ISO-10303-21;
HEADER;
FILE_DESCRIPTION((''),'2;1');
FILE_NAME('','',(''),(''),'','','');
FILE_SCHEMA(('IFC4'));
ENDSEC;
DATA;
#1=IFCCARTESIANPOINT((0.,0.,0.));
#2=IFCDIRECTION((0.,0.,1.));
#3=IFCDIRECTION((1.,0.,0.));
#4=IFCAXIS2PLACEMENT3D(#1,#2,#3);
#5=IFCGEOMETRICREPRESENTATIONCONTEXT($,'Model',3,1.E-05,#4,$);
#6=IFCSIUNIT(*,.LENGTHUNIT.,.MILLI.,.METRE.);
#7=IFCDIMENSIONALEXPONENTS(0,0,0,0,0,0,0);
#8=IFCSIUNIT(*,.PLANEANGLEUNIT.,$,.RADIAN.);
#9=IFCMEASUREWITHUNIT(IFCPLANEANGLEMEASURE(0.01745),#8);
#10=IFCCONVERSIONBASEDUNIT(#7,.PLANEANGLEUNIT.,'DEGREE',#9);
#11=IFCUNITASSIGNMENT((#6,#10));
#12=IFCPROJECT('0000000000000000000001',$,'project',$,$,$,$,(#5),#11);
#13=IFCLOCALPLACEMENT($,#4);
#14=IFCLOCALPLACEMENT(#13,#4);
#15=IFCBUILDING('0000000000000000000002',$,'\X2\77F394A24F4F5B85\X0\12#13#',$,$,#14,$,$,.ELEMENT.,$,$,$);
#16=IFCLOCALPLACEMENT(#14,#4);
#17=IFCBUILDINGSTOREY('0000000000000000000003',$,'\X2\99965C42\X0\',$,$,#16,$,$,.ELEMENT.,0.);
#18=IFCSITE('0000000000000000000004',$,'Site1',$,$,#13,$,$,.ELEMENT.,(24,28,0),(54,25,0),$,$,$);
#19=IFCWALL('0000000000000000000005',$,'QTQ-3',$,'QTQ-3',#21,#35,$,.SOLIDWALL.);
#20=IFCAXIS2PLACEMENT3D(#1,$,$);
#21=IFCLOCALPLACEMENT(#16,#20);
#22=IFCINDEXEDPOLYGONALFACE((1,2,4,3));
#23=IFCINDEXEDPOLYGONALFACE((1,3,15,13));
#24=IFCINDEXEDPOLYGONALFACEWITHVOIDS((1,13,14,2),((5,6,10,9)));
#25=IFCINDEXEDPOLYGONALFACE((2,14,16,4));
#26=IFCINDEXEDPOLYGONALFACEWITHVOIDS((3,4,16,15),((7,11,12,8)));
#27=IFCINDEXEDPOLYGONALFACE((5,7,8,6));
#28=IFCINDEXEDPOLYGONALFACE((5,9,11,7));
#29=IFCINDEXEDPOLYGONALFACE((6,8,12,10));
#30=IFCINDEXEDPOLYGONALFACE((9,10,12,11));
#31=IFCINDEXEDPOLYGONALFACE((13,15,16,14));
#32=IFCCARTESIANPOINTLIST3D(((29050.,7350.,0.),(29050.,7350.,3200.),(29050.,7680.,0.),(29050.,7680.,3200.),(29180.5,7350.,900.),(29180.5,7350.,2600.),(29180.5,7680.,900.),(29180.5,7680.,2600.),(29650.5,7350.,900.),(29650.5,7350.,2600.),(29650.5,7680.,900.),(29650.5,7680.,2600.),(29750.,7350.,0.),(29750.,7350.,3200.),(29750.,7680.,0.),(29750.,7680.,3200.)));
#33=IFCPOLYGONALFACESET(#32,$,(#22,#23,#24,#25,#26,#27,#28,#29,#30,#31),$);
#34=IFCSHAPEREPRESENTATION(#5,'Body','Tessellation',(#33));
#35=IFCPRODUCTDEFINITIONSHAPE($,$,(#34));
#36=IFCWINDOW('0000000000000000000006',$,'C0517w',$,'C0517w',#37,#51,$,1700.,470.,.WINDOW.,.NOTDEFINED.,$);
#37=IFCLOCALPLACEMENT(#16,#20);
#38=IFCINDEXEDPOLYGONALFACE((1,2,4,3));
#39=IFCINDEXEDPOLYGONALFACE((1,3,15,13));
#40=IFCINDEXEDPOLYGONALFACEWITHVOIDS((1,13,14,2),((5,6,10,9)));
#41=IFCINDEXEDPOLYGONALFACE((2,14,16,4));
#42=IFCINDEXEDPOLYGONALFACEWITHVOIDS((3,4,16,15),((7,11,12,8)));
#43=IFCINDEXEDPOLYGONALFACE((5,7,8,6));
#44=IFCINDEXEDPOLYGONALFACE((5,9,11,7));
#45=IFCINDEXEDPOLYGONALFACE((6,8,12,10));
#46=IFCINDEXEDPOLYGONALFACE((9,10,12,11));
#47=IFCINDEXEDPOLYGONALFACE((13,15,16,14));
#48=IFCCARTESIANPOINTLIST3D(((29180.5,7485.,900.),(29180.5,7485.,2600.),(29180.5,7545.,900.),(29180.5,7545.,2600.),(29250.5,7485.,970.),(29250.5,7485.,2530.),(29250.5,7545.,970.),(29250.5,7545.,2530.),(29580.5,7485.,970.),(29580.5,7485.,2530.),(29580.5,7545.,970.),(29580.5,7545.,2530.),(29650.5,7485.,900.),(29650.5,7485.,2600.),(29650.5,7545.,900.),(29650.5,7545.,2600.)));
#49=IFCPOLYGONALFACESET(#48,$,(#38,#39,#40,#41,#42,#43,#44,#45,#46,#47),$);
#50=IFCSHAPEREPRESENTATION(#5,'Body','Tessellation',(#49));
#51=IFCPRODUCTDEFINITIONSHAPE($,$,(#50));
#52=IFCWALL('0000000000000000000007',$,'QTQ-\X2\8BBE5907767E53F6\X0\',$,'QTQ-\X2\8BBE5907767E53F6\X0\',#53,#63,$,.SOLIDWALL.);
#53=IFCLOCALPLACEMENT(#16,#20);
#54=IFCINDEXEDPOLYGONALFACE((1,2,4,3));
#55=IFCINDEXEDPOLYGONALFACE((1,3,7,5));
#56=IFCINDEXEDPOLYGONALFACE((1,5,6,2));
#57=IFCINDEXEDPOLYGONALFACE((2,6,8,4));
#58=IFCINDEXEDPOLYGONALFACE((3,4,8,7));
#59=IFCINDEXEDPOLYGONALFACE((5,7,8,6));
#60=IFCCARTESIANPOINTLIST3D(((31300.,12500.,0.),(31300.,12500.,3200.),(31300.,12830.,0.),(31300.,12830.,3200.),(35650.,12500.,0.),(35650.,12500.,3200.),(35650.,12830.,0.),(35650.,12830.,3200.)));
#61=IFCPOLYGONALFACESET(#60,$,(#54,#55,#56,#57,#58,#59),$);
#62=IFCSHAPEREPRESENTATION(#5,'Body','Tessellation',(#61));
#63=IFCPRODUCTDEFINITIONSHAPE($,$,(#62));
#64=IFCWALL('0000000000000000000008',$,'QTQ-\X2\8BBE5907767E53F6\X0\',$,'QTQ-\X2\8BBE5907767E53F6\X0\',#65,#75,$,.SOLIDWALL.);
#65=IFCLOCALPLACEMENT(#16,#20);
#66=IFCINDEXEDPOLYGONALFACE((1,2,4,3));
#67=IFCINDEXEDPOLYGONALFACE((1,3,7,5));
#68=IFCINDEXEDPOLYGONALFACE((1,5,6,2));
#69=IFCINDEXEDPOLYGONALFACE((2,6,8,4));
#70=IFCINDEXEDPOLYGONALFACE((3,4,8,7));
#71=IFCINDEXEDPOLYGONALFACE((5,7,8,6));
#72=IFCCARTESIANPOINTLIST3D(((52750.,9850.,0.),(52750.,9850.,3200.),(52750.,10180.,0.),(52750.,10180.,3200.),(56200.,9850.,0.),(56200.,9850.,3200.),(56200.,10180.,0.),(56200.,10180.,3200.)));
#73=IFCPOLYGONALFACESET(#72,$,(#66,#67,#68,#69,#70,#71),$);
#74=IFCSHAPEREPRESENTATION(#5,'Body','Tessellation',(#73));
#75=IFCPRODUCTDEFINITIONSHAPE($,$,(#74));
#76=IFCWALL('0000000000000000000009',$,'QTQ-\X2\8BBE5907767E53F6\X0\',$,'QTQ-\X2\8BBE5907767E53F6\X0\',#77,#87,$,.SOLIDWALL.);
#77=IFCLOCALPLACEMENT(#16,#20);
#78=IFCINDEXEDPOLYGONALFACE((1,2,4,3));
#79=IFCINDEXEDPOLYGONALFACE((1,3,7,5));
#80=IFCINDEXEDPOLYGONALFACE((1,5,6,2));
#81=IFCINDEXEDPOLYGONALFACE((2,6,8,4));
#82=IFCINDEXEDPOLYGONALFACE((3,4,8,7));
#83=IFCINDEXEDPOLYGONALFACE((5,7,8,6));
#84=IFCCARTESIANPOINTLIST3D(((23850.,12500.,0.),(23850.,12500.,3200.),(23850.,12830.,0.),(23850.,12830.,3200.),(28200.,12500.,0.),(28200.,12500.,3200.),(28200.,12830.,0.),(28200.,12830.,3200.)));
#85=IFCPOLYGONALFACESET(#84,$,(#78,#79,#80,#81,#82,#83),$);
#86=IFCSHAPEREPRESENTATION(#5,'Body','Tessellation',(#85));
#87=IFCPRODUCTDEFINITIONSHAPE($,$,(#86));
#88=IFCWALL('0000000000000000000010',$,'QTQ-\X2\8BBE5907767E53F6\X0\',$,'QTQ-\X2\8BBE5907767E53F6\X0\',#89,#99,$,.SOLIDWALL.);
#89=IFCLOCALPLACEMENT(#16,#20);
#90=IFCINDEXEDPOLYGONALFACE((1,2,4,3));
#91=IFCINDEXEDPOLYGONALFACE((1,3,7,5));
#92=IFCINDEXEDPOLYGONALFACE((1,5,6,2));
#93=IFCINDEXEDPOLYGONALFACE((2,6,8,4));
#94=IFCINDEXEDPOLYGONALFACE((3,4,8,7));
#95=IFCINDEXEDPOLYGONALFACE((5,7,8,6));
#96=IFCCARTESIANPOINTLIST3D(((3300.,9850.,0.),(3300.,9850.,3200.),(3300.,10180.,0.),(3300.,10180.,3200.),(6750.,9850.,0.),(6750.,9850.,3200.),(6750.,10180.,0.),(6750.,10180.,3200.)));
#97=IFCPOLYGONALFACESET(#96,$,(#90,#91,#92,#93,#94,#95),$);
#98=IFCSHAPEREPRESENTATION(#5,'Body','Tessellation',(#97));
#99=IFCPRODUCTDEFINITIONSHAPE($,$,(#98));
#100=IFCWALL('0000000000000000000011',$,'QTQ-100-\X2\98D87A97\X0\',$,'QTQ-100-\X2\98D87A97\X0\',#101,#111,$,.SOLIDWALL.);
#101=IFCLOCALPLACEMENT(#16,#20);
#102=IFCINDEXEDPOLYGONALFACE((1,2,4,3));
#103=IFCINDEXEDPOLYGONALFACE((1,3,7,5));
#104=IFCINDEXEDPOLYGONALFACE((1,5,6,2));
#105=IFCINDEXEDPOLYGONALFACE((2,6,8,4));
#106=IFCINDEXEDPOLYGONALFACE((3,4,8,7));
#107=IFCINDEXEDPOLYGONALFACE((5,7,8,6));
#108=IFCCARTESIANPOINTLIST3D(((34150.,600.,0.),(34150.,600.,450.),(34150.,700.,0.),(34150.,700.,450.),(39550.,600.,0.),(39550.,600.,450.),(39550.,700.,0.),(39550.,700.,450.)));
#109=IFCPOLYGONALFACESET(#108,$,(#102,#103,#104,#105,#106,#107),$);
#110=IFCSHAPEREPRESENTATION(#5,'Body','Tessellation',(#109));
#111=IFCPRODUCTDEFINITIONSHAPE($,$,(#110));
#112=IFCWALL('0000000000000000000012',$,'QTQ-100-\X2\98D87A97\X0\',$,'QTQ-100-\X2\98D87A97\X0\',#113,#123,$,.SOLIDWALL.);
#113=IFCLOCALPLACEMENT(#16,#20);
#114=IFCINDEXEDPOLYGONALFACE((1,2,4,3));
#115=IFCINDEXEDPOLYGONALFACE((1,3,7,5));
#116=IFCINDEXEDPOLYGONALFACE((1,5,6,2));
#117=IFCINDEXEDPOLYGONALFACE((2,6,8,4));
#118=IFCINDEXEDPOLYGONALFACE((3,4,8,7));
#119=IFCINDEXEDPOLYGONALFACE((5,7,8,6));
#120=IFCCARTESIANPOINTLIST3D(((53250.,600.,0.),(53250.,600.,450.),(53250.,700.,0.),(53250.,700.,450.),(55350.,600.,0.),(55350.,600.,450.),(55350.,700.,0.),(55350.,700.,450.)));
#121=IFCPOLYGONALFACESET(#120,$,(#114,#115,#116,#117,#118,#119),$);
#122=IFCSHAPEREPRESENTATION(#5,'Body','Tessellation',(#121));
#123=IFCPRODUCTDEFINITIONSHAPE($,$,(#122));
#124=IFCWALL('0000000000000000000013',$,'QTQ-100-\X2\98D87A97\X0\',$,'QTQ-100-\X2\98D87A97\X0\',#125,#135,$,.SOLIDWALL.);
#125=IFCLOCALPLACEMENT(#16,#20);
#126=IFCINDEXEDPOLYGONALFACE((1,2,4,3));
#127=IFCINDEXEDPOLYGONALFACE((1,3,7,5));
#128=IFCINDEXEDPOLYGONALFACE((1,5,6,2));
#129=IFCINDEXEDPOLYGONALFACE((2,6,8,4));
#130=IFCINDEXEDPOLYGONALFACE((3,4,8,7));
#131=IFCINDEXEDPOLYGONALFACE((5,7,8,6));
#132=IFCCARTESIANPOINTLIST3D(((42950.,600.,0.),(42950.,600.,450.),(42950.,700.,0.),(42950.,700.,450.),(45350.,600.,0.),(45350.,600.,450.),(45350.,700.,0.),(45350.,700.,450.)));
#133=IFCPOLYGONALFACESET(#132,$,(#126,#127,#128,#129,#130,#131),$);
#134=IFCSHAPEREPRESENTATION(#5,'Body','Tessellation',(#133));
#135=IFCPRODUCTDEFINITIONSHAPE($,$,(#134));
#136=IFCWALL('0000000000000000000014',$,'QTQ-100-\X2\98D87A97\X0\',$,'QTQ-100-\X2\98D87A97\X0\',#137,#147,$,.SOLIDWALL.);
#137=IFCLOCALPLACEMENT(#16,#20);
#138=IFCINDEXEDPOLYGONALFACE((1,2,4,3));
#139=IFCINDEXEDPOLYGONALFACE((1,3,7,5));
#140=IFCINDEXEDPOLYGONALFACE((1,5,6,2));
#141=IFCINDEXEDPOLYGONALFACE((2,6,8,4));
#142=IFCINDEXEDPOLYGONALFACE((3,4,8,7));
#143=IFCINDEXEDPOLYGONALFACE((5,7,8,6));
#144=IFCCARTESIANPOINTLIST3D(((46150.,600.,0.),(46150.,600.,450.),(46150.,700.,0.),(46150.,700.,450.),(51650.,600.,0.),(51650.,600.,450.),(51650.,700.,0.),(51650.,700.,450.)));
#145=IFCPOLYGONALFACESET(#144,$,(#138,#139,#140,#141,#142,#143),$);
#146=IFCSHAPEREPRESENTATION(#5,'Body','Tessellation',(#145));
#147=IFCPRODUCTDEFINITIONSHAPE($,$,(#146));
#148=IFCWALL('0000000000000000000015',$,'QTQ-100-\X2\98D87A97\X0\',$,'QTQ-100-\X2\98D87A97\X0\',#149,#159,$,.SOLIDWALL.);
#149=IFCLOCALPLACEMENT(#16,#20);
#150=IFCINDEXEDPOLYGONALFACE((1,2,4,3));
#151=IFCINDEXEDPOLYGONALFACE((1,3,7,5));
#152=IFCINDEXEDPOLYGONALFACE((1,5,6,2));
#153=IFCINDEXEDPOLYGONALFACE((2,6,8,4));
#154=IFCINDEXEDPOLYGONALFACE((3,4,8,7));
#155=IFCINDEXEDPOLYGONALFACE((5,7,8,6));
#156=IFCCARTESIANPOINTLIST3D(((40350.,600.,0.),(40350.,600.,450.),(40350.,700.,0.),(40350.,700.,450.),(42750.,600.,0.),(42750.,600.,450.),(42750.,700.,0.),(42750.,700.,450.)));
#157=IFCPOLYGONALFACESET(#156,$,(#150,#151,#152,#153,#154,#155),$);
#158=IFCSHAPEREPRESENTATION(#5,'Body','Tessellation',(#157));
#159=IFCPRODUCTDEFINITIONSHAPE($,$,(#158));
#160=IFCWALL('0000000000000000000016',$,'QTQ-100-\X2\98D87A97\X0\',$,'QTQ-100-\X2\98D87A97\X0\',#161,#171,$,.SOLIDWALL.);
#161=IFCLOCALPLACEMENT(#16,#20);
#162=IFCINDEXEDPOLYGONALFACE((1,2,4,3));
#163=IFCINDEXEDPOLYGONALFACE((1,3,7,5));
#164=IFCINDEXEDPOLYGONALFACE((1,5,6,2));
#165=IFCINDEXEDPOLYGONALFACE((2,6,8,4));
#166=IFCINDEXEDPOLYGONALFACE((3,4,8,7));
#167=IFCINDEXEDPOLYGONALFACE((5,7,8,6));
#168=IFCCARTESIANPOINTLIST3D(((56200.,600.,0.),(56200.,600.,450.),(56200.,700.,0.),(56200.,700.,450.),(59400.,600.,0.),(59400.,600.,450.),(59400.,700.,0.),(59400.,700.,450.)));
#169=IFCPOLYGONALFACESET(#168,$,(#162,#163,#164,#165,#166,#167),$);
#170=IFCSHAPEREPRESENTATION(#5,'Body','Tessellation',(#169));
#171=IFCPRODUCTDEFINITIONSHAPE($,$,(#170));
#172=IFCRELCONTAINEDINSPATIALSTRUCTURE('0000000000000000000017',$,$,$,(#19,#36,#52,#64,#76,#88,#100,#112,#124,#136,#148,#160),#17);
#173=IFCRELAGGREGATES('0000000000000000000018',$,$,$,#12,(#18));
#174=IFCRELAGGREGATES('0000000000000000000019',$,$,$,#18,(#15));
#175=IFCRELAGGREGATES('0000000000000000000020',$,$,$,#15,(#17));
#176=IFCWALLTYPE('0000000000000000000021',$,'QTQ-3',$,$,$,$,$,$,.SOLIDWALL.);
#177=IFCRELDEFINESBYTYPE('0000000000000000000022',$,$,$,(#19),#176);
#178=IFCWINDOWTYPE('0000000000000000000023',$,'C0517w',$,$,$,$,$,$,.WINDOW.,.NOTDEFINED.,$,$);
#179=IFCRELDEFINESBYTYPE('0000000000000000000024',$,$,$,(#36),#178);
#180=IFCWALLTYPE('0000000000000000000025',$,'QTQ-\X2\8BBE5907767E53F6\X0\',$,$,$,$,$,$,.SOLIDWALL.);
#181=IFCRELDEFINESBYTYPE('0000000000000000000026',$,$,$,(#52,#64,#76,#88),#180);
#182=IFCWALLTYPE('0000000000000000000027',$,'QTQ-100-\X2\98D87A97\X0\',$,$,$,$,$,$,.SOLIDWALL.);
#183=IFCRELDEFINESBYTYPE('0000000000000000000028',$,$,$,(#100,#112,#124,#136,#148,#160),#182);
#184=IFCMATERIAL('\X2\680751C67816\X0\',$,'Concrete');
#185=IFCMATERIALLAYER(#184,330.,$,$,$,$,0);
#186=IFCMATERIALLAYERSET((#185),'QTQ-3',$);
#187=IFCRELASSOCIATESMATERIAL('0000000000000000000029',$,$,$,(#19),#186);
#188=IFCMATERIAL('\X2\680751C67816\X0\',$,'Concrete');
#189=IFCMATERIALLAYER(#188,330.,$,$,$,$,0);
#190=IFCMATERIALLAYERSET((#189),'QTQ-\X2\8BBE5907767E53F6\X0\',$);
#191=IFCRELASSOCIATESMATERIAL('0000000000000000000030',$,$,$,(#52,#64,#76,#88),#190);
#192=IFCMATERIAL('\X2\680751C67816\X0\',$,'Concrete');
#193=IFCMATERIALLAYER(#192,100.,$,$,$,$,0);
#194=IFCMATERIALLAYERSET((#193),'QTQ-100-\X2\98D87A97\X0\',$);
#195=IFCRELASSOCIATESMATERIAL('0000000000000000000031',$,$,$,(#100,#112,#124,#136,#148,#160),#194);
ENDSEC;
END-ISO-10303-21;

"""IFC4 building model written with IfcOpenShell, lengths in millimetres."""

from ifc_helpers import new_model, entity, si_unit, converted_unit, frame, origin_with_axes, place, context, project, spatial, polyline, outline, extrude, material, layer, layer_set, type_object, element, fill, save


model = new_model("IFC4")

# Units and contexts
model_context = context("Model", 3, precision=1e-05, world=origin_with_axes())
ifc_project = project(units=[si_unit("LENGTHUNIT", "METRE", prefix="MILLI"), converted_unit("PLANEANGLEUNIT", "DEGREE", entity("IfcPlaneAngleMeasure", 0.01745), si_unit("PLANEANGLEUNIT", "RADIAN"), dimensions=[0, 0, 0, 0, 0, 0, 0])], contexts=[model_context])

# Site, building, storey
site_placement = place(None, origin_with_axes())
site = spatial("IfcSite", under=ifc_project, at=site_placement, Name="Site1", CompositionType="ELEMENT", RefLatitude=(24, 28, 0), RefLongitude=(54, 25, 0))
building_placement = place(site_placement, origin_with_axes())
building = spatial("IfcBuilding", under=site, at=building_placement, Name="石钢住宅12#13#", CompositionType="ELEMENT")
storey_placement = place(building_placement, origin_with_axes())
storey = spatial("IfcBuildingStorey", under=building, at=storey_placement, Name="首层", CompositionType="ELEMENT", Elevation=0.0)

# Wall, opening, window
ifc_material_1 = material(Name="标准砖", Category="Concrete")
ifc_layer_1 = layer(ifc_material_1, 330.0, Priority=0)
ifc_layer_set_1 = layer_set([ifc_layer_1], Name="QTQ-3")
wall_type_1 = type_object("IfcWallType", Name="QTQ-3", PredefinedType="SOLIDWALL")
wall_1_placement = place(storey_placement, origin_with_axes())
wall_1 = element("IfcWall", 1, at=wall_1_placement, inside=storey, type_object=wall_type_1, material=ifc_layer_set_1, Name="QTQ-3", ObjectType="QTQ-3", PredefinedType="SOLIDWALL", context=model_context, shape_type="SweptSolid", body=[
    extrude(outline(polyline([(0.0, 0.0), (3200.0, 0.0), (3200.0, 700.0), (0.0, 700.0), (0.0, 0.0)])), frame((29050.0, 7680.0, 3200.0), z_axis=(0.0, -1.0, 0.0), x_axis=(0.0, 0.0, -1.0)), (0.0, 0.0, 1.0), 330.0),
])
opening_placement = place(storey_placement, origin_with_axes())
opening = element("IfcOpeningElement", 2, at=opening_placement, cuts=wall_1, PredefinedType="OPENING", context=model_context, shape_type="SweptSolid", body=[
    extrude(outline(polyline([(0.0, 0.0), (470.0, 0.0), (470.0, 1700.0), (0.0, 1700.0), (0.0, 0.0)])), frame((29180.5, 8680.0, 900.0), z_axis=(0.0, -1.0, 0.0), x_axis=(1.0, 0.0, 0.0)), (0.0, 0.0, 1.0), 2330.0),
])
window_type = type_object("IfcWindowType", Name="C0517w", PartitioningType="NOTDEFINED", PredefinedType="WINDOW")
window_placement = place(storey_placement, origin_with_axes())
window = element("IfcWindow", 3, at=window_placement, inside=storey, type_object=window_type, Name="C0517w", ObjectType="C0517w", OverallHeight=1700.0, OverallWidth=470.0, PartitioningType="NOTDEFINED", PredefinedType="WINDOW", context=model_context, shape_type="SweptSolid", body=[
    extrude(outline(polyline([(-235.0, -850.0), (235.0, -850.0), (235.0, 850.0), (-235.0, 850.0), (-235.0, -850.0)]), holes=[polyline([(-165.0, -780.0), (-165.0, 780.0), (165.0, 780.0), (165.0, -780.0), (-165.0, -780.0)])]), frame((29415.5, 7545.0, 1750.0), z_axis=(0.0, -1.0, 0.0), x_axis=(1.0, 0.0, 0.0)), (0.0, 0.0, 1.0), 60.0),
])
fill(opening, window)

# Walls
ifc_material_2 = material(Name="标准砖", Category="Concrete")
ifc_layer_2 = layer(ifc_material_2, 330.0, Priority=0)
ifc_layer_set_2 = layer_set([ifc_layer_2], Name="QTQ-设备百叶")
wall_type_2 = type_object("IfcWallType", Name="QTQ-设备百叶", PredefinedType="SOLIDWALL")
wall_2_placement = place(storey_placement, origin_with_axes())
element("IfcWall", 4, at=wall_2_placement, inside=storey, type_object=wall_type_2, material=ifc_layer_set_2, Name="QTQ-设备百叶", ObjectType="QTQ-设备百叶", PredefinedType="SOLIDWALL", context=model_context, shape_type="SweptSolid", body=[
    extrude(outline(polyline([(0.0, 0.0), (3200.0, 0.0), (3200.0, 4350.0), (0.0, 4350.0), (0.0, 0.0)])), frame((31300.0, 12830.0, 3200.0), z_axis=(0.0, -1.0, 0.0), x_axis=(0.0, 0.0, -1.0)), (0.0, 0.0, 1.0), 330.0),
])
wall_3_placement = place(storey_placement, origin_with_axes())
element("IfcWall", 5, at=wall_3_placement, inside=storey, type_object=wall_type_2, material=ifc_layer_set_2, Name="QTQ-设备百叶", ObjectType="QTQ-设备百叶", PredefinedType="SOLIDWALL", context=model_context, shape_type="SweptSolid", body=[
    extrude(outline(polyline([(0.0, 0.0), (3200.0, 0.0), (3200.0, 3450.0), (0.0, 3450.0), (0.0, 0.0)])), frame((56200.0, 9850.0, 3200.0), z_axis=(0.0, 1.0, 0.0), x_axis=(0.0, 0.0, -1.0)), (0.0, 0.0, 1.0), 330.0),
])
wall_4_placement = place(storey_placement, origin_with_axes())
element("IfcWall", 6, at=wall_4_placement, inside=storey, type_object=wall_type_2, material=ifc_layer_set_2, Name="QTQ-设备百叶", ObjectType="QTQ-设备百叶", PredefinedType="SOLIDWALL", context=model_context, shape_type="SweptSolid", body=[
    extrude(outline(polyline([(0.0, 0.0), (3200.0, 0.0), (3200.0, 4350.0), (0.0, 4350.0), (0.0, 0.0)])), frame((28200.0, 12500.0, 3200.0), z_axis=(0.0, 1.0, 0.0), x_axis=(0.0, 0.0, -1.0)), (0.0, 0.0, 1.0), 330.0),
])
wall_5_placement = place(storey_placement, origin_with_axes())
element("IfcWall", 7, at=wall_5_placement, inside=storey, type_object=wall_type_2, material=ifc_layer_set_2, Name="QTQ-设备百叶", ObjectType="QTQ-设备百叶", PredefinedType="SOLIDWALL", context=model_context, shape_type="SweptSolid", body=[
    extrude(outline(polyline([(0.0, 0.0), (3200.0, 0.0), (3200.0, 3450.0), (0.0, 3450.0), (0.0, 0.0)])), frame((3300.0, 10180.0, 3200.0), z_axis=(0.0, -1.0, 0.0), x_axis=(0.0, 0.0, -1.0)), (0.0, 0.0, 1.0), 330.0),
])
ifc_material_3 = material(Name="标准砖", Category="Concrete")
ifc_layer_3 = layer(ifc_material_3, 100.0, Priority=0)
ifc_layer_set_3 = layer_set([ifc_layer_3], Name="QTQ-100-飘窗")
wall_type_3 = type_object("IfcWallType", Name="QTQ-100-飘窗", PredefinedType="SOLIDWALL")
wall_6_placement = place(storey_placement, origin_with_axes())
element("IfcWall", 8, at=wall_6_placement, inside=storey, type_object=wall_type_3, material=ifc_layer_set_3, Name="QTQ-100-飘窗", ObjectType="QTQ-100-飘窗", PredefinedType="SOLIDWALL", context=model_context, shape_type="SweptSolid", body=[
    extrude(outline(polyline([(0.0, 0.0), (450.0, 0.0), (450.0, 5400.0), (0.0, 5400.0), (0.0, 0.0)])), frame((39550.0, 600.0, 450.0), z_axis=(0.0, 1.0, 0.0), x_axis=(0.0, 0.0, -1.0)), (0.0, 0.0, 1.0), 100.0),
])
wall_7_placement = place(storey_placement, origin_with_axes())
element("IfcWall", 9, at=wall_7_placement, inside=storey, type_object=wall_type_3, material=ifc_layer_set_3, Name="QTQ-100-飘窗", ObjectType="QTQ-100-飘窗", PredefinedType="SOLIDWALL", context=model_context, shape_type="SweptSolid", body=[
    extrude(outline(polyline([(0.0, 0.0), (450.0, 0.0), (450.0, 2100.0), (0.0, 2100.0), (0.0, 0.0)])), frame((55350.0, 600.0, 450.0), z_axis=(0.0, 1.0, 0.0), x_axis=(0.0, 0.0, -1.0)), (0.0, 0.0, 1.0), 100.0),
])
wall_8_placement = place(storey_placement, origin_with_axes())
element("IfcWall", 10, at=wall_8_placement, inside=storey, type_object=wall_type_3, material=ifc_layer_set_3, Name="QTQ-100-飘窗", ObjectType="QTQ-100-飘窗", PredefinedType="SOLIDWALL", context=model_context, shape_type="SweptSolid", body=[
    extrude(outline(polyline([(0.0, 0.0), (450.0, 0.0), (450.0, 2400.0), (0.0, 2400.0), (0.0, 0.0)])), frame((45350.0, 600.0, 450.0), z_axis=(0.0, 1.0, 0.0), x_axis=(0.0, 0.0, -1.0)), (0.0, 0.0, 1.0), 100.0),
])
wall_9_placement = place(storey_placement, origin_with_axes())
element("IfcWall", 11, at=wall_9_placement, inside=storey, type_object=wall_type_3, material=ifc_layer_set_3, Name="QTQ-100-飘窗", ObjectType="QTQ-100-飘窗", PredefinedType="SOLIDWALL", context=model_context, shape_type="SweptSolid", body=[
    extrude(outline(polyline([(0.0, 0.0), (450.0, 0.0), (450.0, 5500.0), (0.0, 5500.0), (0.0, 0.0)])), frame((51650.0, 600.0, 450.0), z_axis=(0.0, 1.0, 0.0), x_axis=(0.0, 0.0, -1.0)), (0.0, 0.0, 1.0), 100.0),
])
wall_10_placement = place(storey_placement, origin_with_axes())
element("IfcWall", 12, at=wall_10_placement, inside=storey, type_object=wall_type_3, material=ifc_layer_set_3, Name="QTQ-100-飘窗", ObjectType="QTQ-100-飘窗", PredefinedType="SOLIDWALL", context=model_context, shape_type="SweptSolid", body=[
    extrude(outline(polyline([(0.0, 0.0), (450.0, 0.0), (450.0, 2400.0), (0.0, 2400.0), (0.0, 0.0)])), frame((42750.0, 600.0, 450.0), z_axis=(0.0, 1.0, 0.0), x_axis=(0.0, 0.0, -1.0)), (0.0, 0.0, 1.0), 100.0),
])
wall_11_placement = place(storey_placement, origin_with_axes())
element("IfcWall", 13, at=wall_11_placement, inside=storey, type_object=wall_type_3, material=ifc_layer_set_3, Name="QTQ-100-飘窗", ObjectType="QTQ-100-飘窗", PredefinedType="SOLIDWALL", context=model_context, shape_type="SweptSolid", body=[
    extrude(outline(polyline([(0.0, 0.0), (450.0, 0.0), (450.0, 3200.0), (0.0, 3200.0), (0.0, 0.0)])), frame((59400.0, 600.0, 450.0), z_axis=(0.0, 1.0, 0.0), x_axis=(0.0, 0.0, -1.0)), (0.0, 0.0, 1.0), 100.0),
])

save(model, "model.ifc")
